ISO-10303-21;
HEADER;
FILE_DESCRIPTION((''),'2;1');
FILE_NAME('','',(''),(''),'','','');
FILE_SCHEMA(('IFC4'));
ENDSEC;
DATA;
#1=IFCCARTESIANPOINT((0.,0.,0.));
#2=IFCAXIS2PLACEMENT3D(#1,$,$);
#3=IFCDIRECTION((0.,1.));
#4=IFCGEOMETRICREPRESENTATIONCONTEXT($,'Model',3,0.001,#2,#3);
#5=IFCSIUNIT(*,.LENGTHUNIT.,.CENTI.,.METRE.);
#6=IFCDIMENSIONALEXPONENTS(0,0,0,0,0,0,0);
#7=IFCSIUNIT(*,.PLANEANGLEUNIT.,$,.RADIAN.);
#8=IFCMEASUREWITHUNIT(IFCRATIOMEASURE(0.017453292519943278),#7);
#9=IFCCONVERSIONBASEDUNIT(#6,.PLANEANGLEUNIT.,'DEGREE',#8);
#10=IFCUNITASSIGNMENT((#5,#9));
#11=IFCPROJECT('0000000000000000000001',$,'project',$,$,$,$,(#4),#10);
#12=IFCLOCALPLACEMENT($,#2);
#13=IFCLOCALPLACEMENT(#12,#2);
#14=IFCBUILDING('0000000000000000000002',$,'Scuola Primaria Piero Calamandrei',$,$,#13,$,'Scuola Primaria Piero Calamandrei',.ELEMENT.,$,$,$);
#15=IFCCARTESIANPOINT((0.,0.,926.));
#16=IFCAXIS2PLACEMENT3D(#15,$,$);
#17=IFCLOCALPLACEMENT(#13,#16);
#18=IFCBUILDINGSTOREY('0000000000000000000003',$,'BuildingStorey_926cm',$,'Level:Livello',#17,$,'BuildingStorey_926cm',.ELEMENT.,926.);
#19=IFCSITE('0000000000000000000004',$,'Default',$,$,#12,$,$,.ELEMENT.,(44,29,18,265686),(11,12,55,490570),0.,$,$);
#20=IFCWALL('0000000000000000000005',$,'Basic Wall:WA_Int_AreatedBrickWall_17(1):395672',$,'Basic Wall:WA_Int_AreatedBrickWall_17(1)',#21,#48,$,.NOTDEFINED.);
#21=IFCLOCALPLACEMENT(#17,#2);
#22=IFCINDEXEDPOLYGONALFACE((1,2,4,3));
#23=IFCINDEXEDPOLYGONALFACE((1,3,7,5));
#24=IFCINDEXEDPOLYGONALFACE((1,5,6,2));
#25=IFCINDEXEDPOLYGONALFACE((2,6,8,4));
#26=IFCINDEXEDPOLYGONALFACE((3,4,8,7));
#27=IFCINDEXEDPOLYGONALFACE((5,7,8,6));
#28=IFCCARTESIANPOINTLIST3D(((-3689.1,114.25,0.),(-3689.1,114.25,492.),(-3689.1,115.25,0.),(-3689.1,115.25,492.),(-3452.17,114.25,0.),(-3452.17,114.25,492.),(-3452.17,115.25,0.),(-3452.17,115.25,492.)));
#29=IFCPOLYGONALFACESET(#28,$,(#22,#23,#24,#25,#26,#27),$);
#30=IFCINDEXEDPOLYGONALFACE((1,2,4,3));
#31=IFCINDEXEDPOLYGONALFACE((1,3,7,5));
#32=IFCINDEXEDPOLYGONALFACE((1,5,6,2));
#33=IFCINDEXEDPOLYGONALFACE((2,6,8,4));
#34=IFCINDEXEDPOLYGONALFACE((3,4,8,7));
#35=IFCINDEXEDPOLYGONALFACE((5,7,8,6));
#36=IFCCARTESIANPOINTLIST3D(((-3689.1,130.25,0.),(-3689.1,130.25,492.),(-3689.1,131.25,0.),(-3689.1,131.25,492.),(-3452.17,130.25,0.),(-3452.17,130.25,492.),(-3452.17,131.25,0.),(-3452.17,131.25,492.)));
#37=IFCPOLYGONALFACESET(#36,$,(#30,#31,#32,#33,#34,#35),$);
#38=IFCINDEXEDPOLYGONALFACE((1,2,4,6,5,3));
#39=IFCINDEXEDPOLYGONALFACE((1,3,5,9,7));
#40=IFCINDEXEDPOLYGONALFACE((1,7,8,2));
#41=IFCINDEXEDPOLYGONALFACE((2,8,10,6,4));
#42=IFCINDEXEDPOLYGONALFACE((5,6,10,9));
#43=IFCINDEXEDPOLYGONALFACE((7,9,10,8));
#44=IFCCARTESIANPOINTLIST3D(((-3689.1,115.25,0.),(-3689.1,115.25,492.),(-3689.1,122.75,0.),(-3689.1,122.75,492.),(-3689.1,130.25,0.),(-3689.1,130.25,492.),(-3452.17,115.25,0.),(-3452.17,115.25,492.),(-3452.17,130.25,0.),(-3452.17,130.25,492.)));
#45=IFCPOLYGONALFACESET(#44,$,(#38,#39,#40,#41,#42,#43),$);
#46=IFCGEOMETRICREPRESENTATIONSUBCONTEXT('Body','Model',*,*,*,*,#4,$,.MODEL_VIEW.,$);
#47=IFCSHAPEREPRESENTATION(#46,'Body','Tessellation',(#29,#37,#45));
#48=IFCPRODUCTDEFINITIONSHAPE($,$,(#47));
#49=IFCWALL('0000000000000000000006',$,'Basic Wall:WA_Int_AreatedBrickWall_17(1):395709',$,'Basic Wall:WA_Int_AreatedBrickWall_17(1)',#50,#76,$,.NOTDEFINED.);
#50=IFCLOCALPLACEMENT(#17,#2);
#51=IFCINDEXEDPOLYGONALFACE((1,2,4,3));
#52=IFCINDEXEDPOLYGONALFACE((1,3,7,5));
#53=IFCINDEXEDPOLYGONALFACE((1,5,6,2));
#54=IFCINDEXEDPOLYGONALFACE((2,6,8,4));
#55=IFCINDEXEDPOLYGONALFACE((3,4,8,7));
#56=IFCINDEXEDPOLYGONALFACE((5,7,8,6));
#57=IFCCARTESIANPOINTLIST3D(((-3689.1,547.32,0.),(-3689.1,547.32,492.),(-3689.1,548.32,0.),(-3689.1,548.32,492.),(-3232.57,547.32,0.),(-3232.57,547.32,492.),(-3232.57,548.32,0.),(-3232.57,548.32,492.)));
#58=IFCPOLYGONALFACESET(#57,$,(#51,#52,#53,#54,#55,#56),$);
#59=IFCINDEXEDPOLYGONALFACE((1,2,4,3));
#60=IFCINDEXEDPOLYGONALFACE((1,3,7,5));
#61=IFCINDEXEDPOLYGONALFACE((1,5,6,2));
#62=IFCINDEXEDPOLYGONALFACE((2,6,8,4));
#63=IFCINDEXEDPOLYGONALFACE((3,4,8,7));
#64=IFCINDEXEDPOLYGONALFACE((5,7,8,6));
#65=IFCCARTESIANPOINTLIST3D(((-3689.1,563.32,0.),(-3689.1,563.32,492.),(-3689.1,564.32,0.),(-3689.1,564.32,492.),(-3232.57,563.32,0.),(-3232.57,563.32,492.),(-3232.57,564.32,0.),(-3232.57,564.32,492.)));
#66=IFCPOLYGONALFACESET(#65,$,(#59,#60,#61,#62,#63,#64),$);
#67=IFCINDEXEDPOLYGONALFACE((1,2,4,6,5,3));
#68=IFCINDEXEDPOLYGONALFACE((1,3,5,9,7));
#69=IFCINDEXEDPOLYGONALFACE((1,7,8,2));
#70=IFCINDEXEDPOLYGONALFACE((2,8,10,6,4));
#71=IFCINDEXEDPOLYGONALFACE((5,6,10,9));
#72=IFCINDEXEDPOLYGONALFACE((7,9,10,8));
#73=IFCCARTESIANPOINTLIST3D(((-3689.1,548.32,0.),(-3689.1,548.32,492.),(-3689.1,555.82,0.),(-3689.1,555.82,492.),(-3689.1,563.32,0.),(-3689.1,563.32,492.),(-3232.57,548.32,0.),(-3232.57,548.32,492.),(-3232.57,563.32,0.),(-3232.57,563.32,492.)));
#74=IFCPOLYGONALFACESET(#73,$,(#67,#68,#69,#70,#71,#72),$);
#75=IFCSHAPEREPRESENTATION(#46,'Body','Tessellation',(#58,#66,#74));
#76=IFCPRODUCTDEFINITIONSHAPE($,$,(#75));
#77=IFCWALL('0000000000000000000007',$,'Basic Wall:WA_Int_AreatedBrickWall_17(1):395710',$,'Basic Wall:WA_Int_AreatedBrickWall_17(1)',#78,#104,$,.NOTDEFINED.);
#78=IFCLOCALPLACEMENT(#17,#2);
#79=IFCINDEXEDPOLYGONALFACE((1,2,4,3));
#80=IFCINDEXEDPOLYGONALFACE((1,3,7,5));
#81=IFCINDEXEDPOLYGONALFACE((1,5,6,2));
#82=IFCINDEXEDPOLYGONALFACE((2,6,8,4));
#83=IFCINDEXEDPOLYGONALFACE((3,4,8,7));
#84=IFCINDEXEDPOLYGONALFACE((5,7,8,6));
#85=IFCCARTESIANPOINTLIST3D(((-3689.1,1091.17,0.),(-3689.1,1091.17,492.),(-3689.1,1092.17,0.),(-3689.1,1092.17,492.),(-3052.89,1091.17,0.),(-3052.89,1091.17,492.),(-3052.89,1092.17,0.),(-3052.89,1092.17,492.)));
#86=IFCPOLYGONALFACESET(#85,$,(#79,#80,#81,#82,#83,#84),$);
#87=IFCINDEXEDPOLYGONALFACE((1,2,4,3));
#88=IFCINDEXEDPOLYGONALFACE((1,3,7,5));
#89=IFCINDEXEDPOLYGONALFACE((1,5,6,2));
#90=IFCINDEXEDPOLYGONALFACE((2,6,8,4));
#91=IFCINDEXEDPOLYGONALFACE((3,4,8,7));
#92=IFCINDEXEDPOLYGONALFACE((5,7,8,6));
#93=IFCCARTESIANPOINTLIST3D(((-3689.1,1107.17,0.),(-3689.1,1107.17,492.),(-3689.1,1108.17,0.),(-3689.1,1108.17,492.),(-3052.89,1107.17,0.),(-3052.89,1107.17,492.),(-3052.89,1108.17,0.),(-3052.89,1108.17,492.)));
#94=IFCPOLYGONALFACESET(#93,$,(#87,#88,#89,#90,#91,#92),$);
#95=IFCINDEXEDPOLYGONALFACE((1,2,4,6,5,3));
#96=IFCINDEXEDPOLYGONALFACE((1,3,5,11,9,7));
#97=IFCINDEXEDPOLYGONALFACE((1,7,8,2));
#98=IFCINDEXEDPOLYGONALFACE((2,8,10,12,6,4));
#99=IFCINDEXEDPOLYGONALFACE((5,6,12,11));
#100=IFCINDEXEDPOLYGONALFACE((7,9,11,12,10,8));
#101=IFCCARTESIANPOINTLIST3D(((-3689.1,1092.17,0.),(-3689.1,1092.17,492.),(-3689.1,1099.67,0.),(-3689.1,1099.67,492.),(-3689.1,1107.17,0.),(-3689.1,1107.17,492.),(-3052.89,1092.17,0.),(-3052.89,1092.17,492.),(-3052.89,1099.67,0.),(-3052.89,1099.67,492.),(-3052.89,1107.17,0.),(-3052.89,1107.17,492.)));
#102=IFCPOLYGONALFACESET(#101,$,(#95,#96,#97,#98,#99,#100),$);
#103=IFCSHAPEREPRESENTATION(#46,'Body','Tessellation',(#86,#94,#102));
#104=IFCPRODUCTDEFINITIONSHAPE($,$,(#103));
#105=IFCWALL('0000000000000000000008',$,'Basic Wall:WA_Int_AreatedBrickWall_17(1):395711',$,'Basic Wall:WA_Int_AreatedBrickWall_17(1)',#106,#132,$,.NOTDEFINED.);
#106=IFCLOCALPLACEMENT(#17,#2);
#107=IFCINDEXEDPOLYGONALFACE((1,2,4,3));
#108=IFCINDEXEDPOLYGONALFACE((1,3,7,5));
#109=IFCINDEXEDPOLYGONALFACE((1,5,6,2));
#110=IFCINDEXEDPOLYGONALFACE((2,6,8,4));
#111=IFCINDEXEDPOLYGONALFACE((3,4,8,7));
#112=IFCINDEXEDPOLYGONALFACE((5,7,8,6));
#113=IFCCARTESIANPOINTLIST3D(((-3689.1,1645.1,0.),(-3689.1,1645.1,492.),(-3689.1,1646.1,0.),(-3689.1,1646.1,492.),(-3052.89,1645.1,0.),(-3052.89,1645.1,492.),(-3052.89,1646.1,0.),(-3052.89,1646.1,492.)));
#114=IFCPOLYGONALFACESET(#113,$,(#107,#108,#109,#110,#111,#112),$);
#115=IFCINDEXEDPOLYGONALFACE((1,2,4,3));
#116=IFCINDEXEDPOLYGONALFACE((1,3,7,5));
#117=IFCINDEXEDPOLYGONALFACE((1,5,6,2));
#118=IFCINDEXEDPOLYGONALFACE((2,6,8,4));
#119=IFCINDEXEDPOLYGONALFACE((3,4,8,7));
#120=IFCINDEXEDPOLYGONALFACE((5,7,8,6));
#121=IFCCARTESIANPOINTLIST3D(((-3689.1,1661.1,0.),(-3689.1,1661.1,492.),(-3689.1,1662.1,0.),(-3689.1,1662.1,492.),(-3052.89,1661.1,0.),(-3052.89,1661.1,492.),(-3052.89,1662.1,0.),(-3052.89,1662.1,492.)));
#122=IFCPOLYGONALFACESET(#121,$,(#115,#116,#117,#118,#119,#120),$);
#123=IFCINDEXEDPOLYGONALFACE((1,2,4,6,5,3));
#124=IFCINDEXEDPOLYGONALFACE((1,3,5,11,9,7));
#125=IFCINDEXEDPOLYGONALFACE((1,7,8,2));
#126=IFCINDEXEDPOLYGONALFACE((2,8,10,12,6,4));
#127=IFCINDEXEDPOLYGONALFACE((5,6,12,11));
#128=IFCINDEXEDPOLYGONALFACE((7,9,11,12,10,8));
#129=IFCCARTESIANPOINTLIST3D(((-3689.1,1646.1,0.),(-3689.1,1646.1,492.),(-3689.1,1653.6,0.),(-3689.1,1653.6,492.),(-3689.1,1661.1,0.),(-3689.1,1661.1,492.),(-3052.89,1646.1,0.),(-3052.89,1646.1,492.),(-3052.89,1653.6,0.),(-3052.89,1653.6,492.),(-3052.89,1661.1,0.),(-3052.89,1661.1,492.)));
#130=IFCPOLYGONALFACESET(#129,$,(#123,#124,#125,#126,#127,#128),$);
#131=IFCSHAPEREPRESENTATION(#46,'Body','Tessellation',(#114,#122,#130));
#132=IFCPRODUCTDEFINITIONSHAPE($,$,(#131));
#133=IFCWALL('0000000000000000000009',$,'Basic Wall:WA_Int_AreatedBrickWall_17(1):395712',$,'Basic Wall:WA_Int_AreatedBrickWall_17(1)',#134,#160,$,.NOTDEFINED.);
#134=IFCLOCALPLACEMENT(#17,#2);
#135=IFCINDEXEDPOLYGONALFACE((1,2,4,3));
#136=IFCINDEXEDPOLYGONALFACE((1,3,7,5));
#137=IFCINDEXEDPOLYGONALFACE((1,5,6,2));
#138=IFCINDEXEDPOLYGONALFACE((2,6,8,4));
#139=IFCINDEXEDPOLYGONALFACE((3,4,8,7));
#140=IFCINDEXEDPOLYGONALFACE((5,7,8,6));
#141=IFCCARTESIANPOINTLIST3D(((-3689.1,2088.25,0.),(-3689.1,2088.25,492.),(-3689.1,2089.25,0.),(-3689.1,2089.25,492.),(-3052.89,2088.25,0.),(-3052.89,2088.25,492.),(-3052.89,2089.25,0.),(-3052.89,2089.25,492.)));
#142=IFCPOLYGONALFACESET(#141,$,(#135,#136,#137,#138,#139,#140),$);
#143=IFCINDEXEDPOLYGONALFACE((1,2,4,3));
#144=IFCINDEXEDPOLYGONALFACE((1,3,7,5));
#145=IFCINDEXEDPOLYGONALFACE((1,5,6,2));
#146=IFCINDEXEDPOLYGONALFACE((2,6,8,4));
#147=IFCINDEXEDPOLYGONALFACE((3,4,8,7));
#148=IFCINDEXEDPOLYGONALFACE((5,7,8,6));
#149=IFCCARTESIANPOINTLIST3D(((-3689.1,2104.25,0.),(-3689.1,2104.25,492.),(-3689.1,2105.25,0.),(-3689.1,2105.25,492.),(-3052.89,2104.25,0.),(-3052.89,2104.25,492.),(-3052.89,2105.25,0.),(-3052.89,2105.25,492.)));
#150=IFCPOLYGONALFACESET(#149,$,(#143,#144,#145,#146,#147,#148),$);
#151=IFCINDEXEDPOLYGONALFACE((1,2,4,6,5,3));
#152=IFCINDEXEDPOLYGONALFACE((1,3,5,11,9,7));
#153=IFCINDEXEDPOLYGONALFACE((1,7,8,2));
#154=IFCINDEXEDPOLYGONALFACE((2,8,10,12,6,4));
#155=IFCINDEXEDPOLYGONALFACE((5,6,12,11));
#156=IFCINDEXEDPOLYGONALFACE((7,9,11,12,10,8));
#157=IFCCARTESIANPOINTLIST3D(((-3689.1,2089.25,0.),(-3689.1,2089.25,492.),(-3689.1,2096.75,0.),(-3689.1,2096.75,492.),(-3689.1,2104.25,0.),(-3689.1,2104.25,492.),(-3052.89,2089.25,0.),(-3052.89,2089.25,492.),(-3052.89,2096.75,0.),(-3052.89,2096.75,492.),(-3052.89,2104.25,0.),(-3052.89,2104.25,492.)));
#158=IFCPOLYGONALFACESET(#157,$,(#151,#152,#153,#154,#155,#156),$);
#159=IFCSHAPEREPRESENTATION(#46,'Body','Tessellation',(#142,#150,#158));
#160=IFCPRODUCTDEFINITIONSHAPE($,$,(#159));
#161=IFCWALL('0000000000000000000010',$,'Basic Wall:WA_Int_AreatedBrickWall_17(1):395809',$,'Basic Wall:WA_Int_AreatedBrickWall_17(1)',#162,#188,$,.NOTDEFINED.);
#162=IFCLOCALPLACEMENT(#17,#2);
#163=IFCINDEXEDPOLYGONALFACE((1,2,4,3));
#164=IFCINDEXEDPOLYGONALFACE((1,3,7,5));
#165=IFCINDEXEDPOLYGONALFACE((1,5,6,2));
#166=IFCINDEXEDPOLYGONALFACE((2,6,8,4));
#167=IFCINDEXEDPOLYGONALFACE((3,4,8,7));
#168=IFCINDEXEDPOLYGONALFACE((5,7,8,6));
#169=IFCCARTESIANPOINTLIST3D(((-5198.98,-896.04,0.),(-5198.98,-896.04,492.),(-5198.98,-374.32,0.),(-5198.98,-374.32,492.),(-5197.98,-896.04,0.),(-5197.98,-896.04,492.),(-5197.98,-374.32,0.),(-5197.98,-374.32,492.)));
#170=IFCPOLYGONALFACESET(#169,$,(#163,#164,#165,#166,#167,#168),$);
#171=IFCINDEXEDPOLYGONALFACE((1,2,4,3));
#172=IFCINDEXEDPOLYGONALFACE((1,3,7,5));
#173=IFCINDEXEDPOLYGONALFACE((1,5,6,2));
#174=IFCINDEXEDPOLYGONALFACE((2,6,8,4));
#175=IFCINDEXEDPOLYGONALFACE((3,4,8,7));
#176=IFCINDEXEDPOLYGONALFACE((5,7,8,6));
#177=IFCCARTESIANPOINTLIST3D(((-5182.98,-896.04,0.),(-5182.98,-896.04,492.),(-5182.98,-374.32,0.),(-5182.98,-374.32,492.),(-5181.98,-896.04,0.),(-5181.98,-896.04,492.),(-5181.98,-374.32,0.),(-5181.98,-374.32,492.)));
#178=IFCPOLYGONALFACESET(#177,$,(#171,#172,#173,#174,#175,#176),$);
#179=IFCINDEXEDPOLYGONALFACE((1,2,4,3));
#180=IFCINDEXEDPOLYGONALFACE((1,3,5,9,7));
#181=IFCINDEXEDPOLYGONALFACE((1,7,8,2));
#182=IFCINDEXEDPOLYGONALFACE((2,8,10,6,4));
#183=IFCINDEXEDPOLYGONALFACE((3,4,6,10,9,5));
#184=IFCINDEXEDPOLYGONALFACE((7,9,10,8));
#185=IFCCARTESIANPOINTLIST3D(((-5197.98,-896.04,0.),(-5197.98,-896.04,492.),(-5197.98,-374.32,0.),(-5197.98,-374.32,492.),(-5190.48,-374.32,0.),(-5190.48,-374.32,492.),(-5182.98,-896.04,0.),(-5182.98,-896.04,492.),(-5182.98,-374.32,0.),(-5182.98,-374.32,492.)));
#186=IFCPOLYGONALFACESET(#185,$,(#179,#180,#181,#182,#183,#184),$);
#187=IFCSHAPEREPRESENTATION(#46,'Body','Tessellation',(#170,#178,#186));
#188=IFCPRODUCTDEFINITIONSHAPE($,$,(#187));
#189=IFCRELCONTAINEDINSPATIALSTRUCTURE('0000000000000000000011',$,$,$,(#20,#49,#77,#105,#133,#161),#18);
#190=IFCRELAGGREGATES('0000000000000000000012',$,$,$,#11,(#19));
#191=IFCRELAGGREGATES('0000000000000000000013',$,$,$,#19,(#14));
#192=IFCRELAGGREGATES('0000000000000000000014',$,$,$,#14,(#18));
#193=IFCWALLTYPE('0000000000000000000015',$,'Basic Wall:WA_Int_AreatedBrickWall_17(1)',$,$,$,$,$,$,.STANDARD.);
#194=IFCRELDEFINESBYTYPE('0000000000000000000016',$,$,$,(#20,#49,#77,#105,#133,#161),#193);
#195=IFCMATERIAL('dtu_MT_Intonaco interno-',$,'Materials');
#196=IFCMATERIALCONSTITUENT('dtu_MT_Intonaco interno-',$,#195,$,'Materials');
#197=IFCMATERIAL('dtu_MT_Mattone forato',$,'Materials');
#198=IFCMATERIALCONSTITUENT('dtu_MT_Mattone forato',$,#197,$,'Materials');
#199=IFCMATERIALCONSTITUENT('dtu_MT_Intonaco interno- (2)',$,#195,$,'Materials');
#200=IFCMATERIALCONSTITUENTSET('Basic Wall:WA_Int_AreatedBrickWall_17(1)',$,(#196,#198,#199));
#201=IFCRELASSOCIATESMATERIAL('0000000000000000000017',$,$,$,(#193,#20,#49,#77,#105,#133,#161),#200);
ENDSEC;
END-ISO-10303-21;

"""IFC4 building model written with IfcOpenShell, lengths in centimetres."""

from ifc_helpers import new_model, entity, si_unit, converted_unit, direction, frame, origin, place, context, subcontext, project, spatial, indexed_curve, outline, extrude, material, constituent, constituent_set, type_object, element, save


model = new_model("IFC4")

# Units and contexts
model_context = context("Model", 3, precision=0.001, world=origin(), true_north=direction((0.0, 1.0)))
body_context = subcontext(model_context, "Body", "Model", "MODEL_VIEW")
ifc_project = project(units=[si_unit("LENGTHUNIT", "METRE", prefix="CENTI"), converted_unit("PLANEANGLEUNIT", "DEGREE", entity("IfcRatioMeasure", 0.017453292519943278), si_unit("PLANEANGLEUNIT", "RADIAN"), dimensions=[0, 0, 0, 0, 0, 0, 0])], contexts=[model_context])

# Site, building, storey
site_placement = place(None, origin())
site = spatial("IfcSite", under=ifc_project, at=site_placement, Name="Default", CompositionType="ELEMENT", RefLatitude=(44, 29, 18, 265686), RefLongitude=(11, 12, 55, 490570), RefElevation=0.0)
building_placement = place(site_placement, origin())
building = spatial("IfcBuilding", under=site, at=building_placement, Name="Scuola Primaria Piero Calamandrei", LongName="Scuola Primaria Piero Calamandrei", CompositionType="ELEMENT")
storey_placement = place(building_placement, frame((0.0, 0.0, 926.0)))
storey = spatial("IfcBuildingStorey", under=building, at=storey_placement, Name="BuildingStorey_926cm", ObjectType="Level:Livello", LongName="BuildingStorey_926cm", CompositionType="ELEMENT", Elevation=926.0)

# Shared definitions
ifc_material_1 = material(Name="dtu_MT_Intonaco interno-", Category="Materials")

# Walls
ifc_constituent_1 = constituent(ifc_material_1, Name="dtu_MT_Intonaco interno-", Category="Materials")
ifc_material_2 = material(Name="dtu_MT_Mattone forato", Category="Materials")
ifc_constituent_2 = constituent(ifc_material_2, Name="dtu_MT_Mattone forato", Category="Materials")
ifc_constituent_3 = constituent(ifc_material_1, Name="dtu_MT_Intonaco interno- (2)", Category="Materials")
ifc_constituent_set_1 = constituent_set(constituents=[ifc_constituent_1, ifc_constituent_2, ifc_constituent_3], Name="Basic Wall:WA_Int_AreatedBrickWall_17(1)")
wall_type_1 = type_object("IfcWallType", Name="Basic Wall:WA_Int_AreatedBrickWall_17(1)", PredefinedType="STANDARD", material=ifc_constituent_set_1)
wall_1_placement = place(storey_placement, frame((-3689.1, 122.75, 0.0)))
element("IfcWall", 1, at=wall_1_placement, inside=storey, type_object=wall_type_1, material=ifc_constituent_set_1, Name="Basic Wall:WA_Int_AreatedBrickWall_17(1):395672", ObjectType="Basic Wall:WA_Int_AreatedBrickWall_17(1)", PredefinedType="NOTDEFINED", context=body_context, shape_type="SweptSolid", body=[
    extrude(outline(indexed_curve([(-0.5, -118.47), (0.5, -118.47), (0.5, 118.47), (-0.5, 118.47), (-0.5, -118.47)], self_intersect=False)), frame((118.47, -8.0, 0.0), z_axis=(0.0, 0.0, 1.0), x_axis=(0.0, 1.0, 0.0)), (0.0, 0.0, 1.0), 492.0),
    extrude(outline(indexed_curve([(-0.5, -118.47), (0.5, -118.47), (0.5, 118.47), (-0.5, 118.47), (-0.5, -118.47)], self_intersect=False)), frame((118.47, 8.0, 0.0), z_axis=(0.0, 0.0, 1.0), x_axis=(0.0, -1.0, 0.0)), (0.0, 0.0, 1.0), 492.0),
    extrude(outline(indexed_curve([(-94.77, -7.5), (142.16, -7.5), (142.16, 7.5), (-94.77, 7.5), (-94.77, 0.0), (-94.77, -7.5)], self_intersect=False)), frame((94.77, 0.0, 0.0)), (0.0, 0.0, 1.0), 492.0),
])
wall_2_placement = place(storey_placement, frame((-3689.1, 555.82, 0.0)))
element("IfcWall", 2, at=wall_2_placement, inside=storey, type_object=wall_type_1, material=ifc_constituent_set_1, Name="Basic Wall:WA_Int_AreatedBrickWall_17(1):395709", ObjectType="Basic Wall:WA_Int_AreatedBrickWall_17(1)", PredefinedType="NOTDEFINED", context=body_context, shape_type="SweptSolid", body=[
    extrude(outline(indexed_curve([(-0.5, -228.27), (0.5, -228.27), (0.5, 228.27), (-0.5, 228.27), (-0.5, -228.27)], self_intersect=False)), frame((228.27, -8.0, 0.0), z_axis=(0.0, 0.0, 1.0), x_axis=(0.0, 1.0, 0.0)), (0.0, 0.0, 1.0), 492.0),
    extrude(outline(indexed_curve([(-0.5, -228.27), (0.5, -228.27), (0.5, 228.27), (-0.5, 228.27), (-0.5, -228.27)], self_intersect=False)), frame((228.27, 8.0, 0.0), z_axis=(0.0, 0.0, 1.0), x_axis=(0.0, -1.0, 0.0)), (0.0, 0.0, 1.0), 492.0),
    extrude(outline(indexed_curve([(-182.61, -7.5), (273.92, -7.5), (273.92, 7.5), (-182.61, 7.5), (-182.61, 0.0), (-182.61, -7.5)], self_intersect=False)), frame((182.61, 0.0, 0.0)), (0.0, 0.0, 1.0), 492.0),
])
wall_3_placement = place(storey_placement, frame((-3689.1, 1099.67, 0.0)))
element("IfcWall", 3, at=wall_3_placement, inside=storey, type_object=wall_type_1, material=ifc_constituent_set_1, Name="Basic Wall:WA_Int_AreatedBrickWall_17(1):395710", ObjectType="Basic Wall:WA_Int_AreatedBrickWall_17(1)", PredefinedType="NOTDEFINED", context=body_context, shape_type="SweptSolid", body=[
    extrude(outline(indexed_curve([(-0.5, -318.1), (0.5, -318.1), (0.5, 318.1), (-0.5, 318.1), (-0.5, -318.1)], self_intersect=False)), frame((318.1, -8.0, 0.0), z_axis=(0.0, 0.0, 1.0), x_axis=(0.0, 1.0, 0.0)), (0.0, 0.0, 1.0), 492.0),
    extrude(outline(indexed_curve([(-0.5, -318.1), (0.5, -318.1), (0.5, 318.1), (-0.5, 318.1), (-0.5, -318.1)], self_intersect=False)), frame((318.1, 8.0, 0.0), z_axis=(0.0, 0.0, 1.0), x_axis=(0.0, -1.0, 0.0)), (0.0, 0.0, 1.0), 492.0),
    extrude(outline(indexed_curve([(-318.1, -7.5), (318.1, -7.5), (318.1, 0.0), (318.1, 7.5), (-318.1, 7.5), (-318.1, 0.0), (-318.1, -7.5)], self_intersect=False)), frame((318.1, 0.0, 0.0)), (0.0, 0.0, 1.0), 492.0),
])
wall_4_placement = place(storey_placement, frame((-3689.1, 1653.6, 0.0)))
element("IfcWall", 4, at=wall_4_placement, inside=storey, type_object=wall_type_1, material=ifc_constituent_set_1, Name="Basic Wall:WA_Int_AreatedBrickWall_17(1):395711", ObjectType="Basic Wall:WA_Int_AreatedBrickWall_17(1)", PredefinedType="NOTDEFINED", context=body_context, shape_type="SweptSolid", body=[
    extrude(outline(indexed_curve([(-0.5, -318.1), (0.5, -318.1), (0.5, 318.1), (-0.5, 318.1), (-0.5, -318.1)], self_intersect=False)), frame((318.1, -8.0, 0.0), z_axis=(0.0, 0.0, 1.0), x_axis=(0.0, 1.0, 0.0)), (0.0, 0.0, 1.0), 492.0),
    extrude(outline(indexed_curve([(-0.5, -318.1), (0.5, -318.1), (0.5, 318.1), (-0.5, 318.1), (-0.5, -318.1)], self_intersect=False)), frame((318.1, 8.0, 0.0), z_axis=(0.0, 0.0, 1.0), x_axis=(0.0, -1.0, 0.0)), (0.0, 0.0, 1.0), 492.0),
    extrude(outline(indexed_curve([(-318.1, -7.5), (318.1, -7.5), (318.1, 0.0), (318.1, 7.5), (-318.1, 7.5), (-318.1, 0.0), (-318.1, -7.5)], self_intersect=False)), frame((318.1, 0.0, 0.0)), (0.0, 0.0, 1.0), 492.0),
])
wall_5_placement = place(storey_placement, frame((-3689.1, 2096.75, 0.0)))
element("IfcWall", 5, at=wall_5_placement, inside=storey, type_object=wall_type_1, material=ifc_constituent_set_1, Name="Basic Wall:WA_Int_AreatedBrickWall_17(1):395712", ObjectType="Basic Wall:WA_Int_AreatedBrickWall_17(1)", PredefinedType="NOTDEFINED", context=body_context, shape_type="SweptSolid", body=[
    extrude(outline(indexed_curve([(-0.5, -318.1), (0.5, -318.1), (0.5, 318.1), (-0.5, 318.1), (-0.5, -318.1)], self_intersect=False)), frame((318.1, -8.0, 0.0), z_axis=(0.0, 0.0, 1.0), x_axis=(0.0, 1.0, 0.0)), (0.0, 0.0, 1.0), 492.0),
    extrude(outline(indexed_curve([(-0.5, -318.1), (0.5, -318.1), (0.5, 318.1), (-0.5, 318.1), (-0.5, -318.1)], self_intersect=False)), frame((318.1, 8.0, 0.0), z_axis=(0.0, 0.0, 1.0), x_axis=(0.0, -1.0, 0.0)), (0.0, 0.0, 1.0), 492.0),
    extrude(outline(indexed_curve([(-318.1, -7.5), (318.1, -7.5), (318.1, 0.0), (318.1, 7.5), (-318.1, 7.5), (-318.1, 0.0), (-318.1, -7.5)], self_intersect=False)), frame((318.1, 0.0, 0.0)), (0.0, 0.0, 1.0), 492.0),
])
wall_6_placement = place(storey_placement, frame((-5190.48, -374.32, 0.0), z_axis=(0.0, 0.0, 1.0), x_axis=(0.0, -1.0, 0.0)))
element("IfcWall", 6, at=wall_6_placement, inside=storey, type_object=wall_type_1, material=ifc_constituent_set_1, Name="Basic Wall:WA_Int_AreatedBrickWall_17(1):395809", ObjectType="Basic Wall:WA_Int_AreatedBrickWall_17(1)", PredefinedType="NOTDEFINED", context=body_context, shape_type="SweptSolid", body=[
    extrude(outline(indexed_curve([(-0.5, -260.86), (0.5, -260.86), (0.5, 260.86), (-0.5, 260.86), (-0.5, -260.86)], self_intersect=False)), frame((260.86, -8.0, 0.0), z_axis=(0.0, 0.0, 1.0), x_axis=(0.0, 1.0, 0.0)), (0.0, 0.0, 1.0), 492.0),
    extrude(outline(indexed_curve([(-0.5, -260.86), (0.5, -260.86), (0.5, 260.86), (-0.5, 260.86), (-0.5, -260.86)], self_intersect=False)), frame((260.86, 8.0, 0.0), z_axis=(0.0, 0.0, 1.0), x_axis=(0.0, -1.0, 0.0)), (0.0, 0.0, 1.0), 492.0),
    extrude(outline(indexed_curve([(-208.69, -7.5), (313.03, -7.5), (313.03, 7.5), (-208.69, 7.5), (-208.69, 0.0), (-208.69, -7.5)], self_intersect=False)), frame((208.69, 0.0, 0.0)), (0.0, 0.0, 1.0), 492.0),
])

save(model, "model.ifc")
